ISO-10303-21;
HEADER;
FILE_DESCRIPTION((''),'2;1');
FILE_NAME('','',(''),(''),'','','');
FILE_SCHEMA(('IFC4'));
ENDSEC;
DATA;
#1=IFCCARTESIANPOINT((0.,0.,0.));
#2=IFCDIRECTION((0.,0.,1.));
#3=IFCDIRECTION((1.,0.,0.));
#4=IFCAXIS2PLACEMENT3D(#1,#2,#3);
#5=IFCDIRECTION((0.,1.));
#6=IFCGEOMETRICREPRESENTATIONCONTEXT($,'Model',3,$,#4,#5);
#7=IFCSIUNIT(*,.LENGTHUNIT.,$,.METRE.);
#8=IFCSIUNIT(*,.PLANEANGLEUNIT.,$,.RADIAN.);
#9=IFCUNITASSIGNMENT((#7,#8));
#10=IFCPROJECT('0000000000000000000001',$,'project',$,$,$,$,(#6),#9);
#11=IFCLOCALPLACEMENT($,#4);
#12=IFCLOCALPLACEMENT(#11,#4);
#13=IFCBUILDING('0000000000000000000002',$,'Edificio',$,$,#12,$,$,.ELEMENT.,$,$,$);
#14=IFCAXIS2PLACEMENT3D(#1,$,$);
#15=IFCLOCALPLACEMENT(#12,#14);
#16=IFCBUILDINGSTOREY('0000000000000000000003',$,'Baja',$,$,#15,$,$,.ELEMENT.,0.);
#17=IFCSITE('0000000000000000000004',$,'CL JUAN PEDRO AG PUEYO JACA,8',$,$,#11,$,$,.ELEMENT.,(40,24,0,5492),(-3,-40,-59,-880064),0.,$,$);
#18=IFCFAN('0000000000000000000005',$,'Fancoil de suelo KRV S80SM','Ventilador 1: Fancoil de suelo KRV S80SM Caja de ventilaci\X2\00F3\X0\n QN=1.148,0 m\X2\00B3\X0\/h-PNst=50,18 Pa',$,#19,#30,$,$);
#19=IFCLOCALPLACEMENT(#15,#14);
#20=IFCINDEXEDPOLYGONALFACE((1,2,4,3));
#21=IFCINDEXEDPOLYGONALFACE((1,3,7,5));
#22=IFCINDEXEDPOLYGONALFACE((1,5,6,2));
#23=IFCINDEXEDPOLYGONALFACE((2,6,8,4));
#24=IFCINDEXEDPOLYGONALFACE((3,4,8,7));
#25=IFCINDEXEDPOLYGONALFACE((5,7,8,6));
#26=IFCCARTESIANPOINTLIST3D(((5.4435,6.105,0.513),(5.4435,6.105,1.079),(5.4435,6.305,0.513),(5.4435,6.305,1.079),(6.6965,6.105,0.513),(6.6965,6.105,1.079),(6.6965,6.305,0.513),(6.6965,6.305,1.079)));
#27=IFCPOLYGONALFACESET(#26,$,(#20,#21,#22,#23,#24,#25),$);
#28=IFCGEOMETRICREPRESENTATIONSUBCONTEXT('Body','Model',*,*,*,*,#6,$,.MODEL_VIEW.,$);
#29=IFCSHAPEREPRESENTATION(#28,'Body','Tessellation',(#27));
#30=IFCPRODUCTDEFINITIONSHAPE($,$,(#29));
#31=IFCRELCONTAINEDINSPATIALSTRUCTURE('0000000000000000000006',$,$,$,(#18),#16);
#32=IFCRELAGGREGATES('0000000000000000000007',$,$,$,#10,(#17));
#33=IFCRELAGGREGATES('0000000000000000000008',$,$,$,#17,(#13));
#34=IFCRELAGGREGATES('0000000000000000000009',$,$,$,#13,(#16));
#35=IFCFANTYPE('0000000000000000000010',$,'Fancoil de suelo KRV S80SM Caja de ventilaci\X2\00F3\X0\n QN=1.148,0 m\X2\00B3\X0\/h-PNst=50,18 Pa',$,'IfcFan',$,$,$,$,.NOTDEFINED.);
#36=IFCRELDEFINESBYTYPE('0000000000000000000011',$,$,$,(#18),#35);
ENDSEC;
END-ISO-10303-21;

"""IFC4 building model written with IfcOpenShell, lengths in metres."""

from ifc_helpers import new_model, si_unit, direction, frame, origin, origin_with_axes, place, context, subcontext, project, spatial, polyline, outline, extrude, source, transform, mapped, type_object, element, save


model = new_model("IFC4")

# Units and contexts
model_context = context("Model", 3, world=origin_with_axes(), true_north=direction((0.0, 1.0)))
body_context = subcontext(model_context, "Body", "Model", "MODEL_VIEW")
ifc_project = project(units=[si_unit("LENGTHUNIT", "METRE"), si_unit("PLANEANGLEUNIT", "RADIAN")], contexts=[model_context])

# Site, building, storey
site_placement = place(None, origin_with_axes())
site = spatial("IfcSite", under=ifc_project, at=site_placement, Name="CL JUAN PEDRO AG PUEYO JACA,8", CompositionType="ELEMENT", RefLatitude=(40, 24, 0, 5492), RefLongitude=(-3, -40, -59, -880064), RefElevation=0.0)
building_placement = place(site_placement, origin_with_axes())
building = spatial("IfcBuilding", under=site, at=building_placement, Name="Edificio", CompositionType="ELEMENT")
storey_placement = place(building_placement, origin())
storey = spatial("IfcBuildingStorey", under=building, at=storey_placement, Name="Baja", CompositionType="ELEMENT", Elevation=0.0)

# Fan
fan_type = type_object("IfcFanType", Name="Fancoil de suelo KRV S80SM Caja de ventilación QN=1.148,0 m³/h-PNst=50,18 Pa", ApplicableOccurrence="IfcFan", PredefinedType="NOTDEFINED")
shared_shape_1 = source(origin_with_axes(), body_context, "Body", "SweptSolid", [
    extrude(outline(polyline([(0.0, -0.2), (0.0, 0.0), (-1.253, 0.0), (-1.253, -0.2), (0.0, -0.2)])), frame((0.0, 0.0, -0.566), z_axis=(0.0, 0.0, 1.0), x_axis=(1.0, 0.0, 0.0)), (0.0, 0.0, 1.0), 0.566),
])
fan_placement = place(storey_placement, origin_with_axes())
element("IfcFan", 1, at=fan_placement, inside=storey, type_object=fan_type, Name="Fancoil de suelo KRV S80SM", Description="Ventilador 1: Fancoil de suelo KRV S80SM Caja de ventilación QN=1.148,0 m³/h-PNst=50,18 Pa", context=body_context, shape_type="MappedRepresentation", body=[
    mapped(shared_shape_1, transform((6.6965, 6.305, 1.079), x_axis=(1.0, 0.0, 0.0), y_axis=(0.0, 1.0, 0.0), z_axis=(0.0, 0.0, 1.0), scale=1.0)),
])

save(model, "model.ifc")
